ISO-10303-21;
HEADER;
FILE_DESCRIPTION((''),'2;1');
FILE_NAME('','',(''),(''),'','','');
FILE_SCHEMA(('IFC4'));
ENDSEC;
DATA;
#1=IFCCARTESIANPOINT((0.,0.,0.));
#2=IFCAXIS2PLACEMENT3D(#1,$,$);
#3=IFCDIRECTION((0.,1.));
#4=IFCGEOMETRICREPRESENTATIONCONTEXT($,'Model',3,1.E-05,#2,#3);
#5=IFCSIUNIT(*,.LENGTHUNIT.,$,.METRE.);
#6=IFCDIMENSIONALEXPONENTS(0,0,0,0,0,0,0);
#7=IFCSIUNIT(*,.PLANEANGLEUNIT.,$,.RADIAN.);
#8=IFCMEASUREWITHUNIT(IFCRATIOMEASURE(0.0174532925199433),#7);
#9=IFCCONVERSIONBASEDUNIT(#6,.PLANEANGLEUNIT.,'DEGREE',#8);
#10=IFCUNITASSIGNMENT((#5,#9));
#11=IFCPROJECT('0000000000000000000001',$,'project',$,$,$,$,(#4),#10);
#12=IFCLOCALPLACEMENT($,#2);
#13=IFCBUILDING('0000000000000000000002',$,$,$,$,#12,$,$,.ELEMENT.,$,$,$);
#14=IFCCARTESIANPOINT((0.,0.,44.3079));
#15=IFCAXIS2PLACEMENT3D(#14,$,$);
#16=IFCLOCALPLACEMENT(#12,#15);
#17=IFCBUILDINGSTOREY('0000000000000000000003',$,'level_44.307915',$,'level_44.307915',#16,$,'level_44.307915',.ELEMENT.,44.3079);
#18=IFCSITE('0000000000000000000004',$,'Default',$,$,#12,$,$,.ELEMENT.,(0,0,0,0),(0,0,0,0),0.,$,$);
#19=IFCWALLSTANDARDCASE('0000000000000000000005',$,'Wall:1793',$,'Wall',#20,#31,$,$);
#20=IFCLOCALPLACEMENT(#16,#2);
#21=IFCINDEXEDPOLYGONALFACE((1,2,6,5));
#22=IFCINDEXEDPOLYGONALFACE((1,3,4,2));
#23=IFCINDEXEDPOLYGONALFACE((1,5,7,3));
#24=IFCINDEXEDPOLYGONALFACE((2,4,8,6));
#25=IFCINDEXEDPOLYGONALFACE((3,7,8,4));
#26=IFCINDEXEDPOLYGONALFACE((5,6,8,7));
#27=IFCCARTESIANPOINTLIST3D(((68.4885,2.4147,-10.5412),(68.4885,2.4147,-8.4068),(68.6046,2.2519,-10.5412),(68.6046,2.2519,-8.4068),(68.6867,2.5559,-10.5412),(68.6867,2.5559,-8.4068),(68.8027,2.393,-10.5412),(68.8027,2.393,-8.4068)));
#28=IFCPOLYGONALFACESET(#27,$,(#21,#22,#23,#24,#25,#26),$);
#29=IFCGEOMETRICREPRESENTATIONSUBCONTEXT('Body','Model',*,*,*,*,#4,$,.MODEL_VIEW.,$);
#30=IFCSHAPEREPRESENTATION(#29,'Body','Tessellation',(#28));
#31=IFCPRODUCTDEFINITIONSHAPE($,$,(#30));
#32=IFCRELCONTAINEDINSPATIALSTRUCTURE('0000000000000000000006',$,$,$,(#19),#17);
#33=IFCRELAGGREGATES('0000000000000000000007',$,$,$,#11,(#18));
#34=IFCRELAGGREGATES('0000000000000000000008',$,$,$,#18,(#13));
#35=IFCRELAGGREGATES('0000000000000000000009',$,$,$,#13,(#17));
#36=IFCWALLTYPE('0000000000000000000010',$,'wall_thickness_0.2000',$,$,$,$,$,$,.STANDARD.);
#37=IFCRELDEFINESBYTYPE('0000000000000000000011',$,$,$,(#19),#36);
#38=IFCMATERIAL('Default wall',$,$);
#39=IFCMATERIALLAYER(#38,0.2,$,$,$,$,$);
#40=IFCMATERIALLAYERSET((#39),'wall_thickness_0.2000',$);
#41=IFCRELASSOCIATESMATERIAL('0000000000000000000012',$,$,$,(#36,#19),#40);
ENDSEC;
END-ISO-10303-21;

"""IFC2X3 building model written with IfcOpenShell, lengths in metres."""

from ifc_helpers import new_model, entity, si_unit, converted_unit, direction, frame, origin, place, context, subcontext, project, spatial, polyline, outline, extrude, material, layer, layer_set, layer_usage, type_object, element, save


model = new_model("IFC2X3")

# Units and contexts
model_context = context("Model", 3, precision=1e-05, world=origin(), true_north=direction((0.0, 1.0)))
body_context = subcontext(model_context, "Body", "Model", "MODEL_VIEW")
ifc_project = project(units=[si_unit("LENGTHUNIT", "METRE"), converted_unit("PLANEANGLEUNIT", "DEGREE", entity("IfcRatioMeasure", 0.0174532925199433), si_unit("PLANEANGLEUNIT", "RADIAN"), dimensions=[0, 0, 0, 0, 0, 0, 0])], contexts=[model_context])

# Site, building, storey
placement_1 = place(None, origin())
site = spatial("IfcSite", under=ifc_project, at=placement_1, Name="Default", CompositionType="ELEMENT", RefLatitude=(0, 0, 0, 0), RefLongitude=(0, 0, 0, 0), RefElevation=0.0)
building = spatial("IfcBuilding", under=site, at=placement_1, CompositionType="ELEMENT")
storey_placement = place(placement_1, frame((0.0, 0.0, 44.3079)))
storey = spatial("IfcBuildingStorey", under=building, at=storey_placement, Name="level_44.307915", ObjectType="level_44.307915", LongName="level_44.307915", CompositionType="ELEMENT", Elevation=44.3079)

# Shared definitions
ifc_material_1 = material(Name="Default wall")
ifc_layer = layer(ifc_material_1, 0.2)
ifc_layer_set = layer_set([ifc_layer], Name="wall_thickness_0.2000")
ifc_layer_usage = layer_usage(ifc_layer_set, "AXIS2", "POSITIVE", -0.1)
wall_type = type_object("IfcWallType", Name="wall_thickness_0.2000", PredefinedType="STANDARD", material=ifc_layer_set)

# Wall
placement_2 = place(placement_1, frame((0.0, 0.0, 33.7667)))
wall_1_placement = place(placement_2, frame((68.7447, 2.4745, 0.0), z_axis=(0.0, 0.0, 1.0), x_axis=(-0.814411, -0.580288, 0.0)))
element("IfcWallStandardCase", 1, at=wall_1_placement, inside=storey, type_object=wall_type, material=ifc_layer_usage, Name="Wall:1793", ObjectType="Wall", context=body_context, shape_type="SweptSolid", body=[
    extrude(outline(polyline([(0.2433, -0.1), (0.2433, 0.1), (0.0, 0.1), (0.0, -0.1), (0.2433, -0.1)])), origin(), (0.0, 0.0, 1.0), 2.1344),
])

save(model, "model.ifc")
